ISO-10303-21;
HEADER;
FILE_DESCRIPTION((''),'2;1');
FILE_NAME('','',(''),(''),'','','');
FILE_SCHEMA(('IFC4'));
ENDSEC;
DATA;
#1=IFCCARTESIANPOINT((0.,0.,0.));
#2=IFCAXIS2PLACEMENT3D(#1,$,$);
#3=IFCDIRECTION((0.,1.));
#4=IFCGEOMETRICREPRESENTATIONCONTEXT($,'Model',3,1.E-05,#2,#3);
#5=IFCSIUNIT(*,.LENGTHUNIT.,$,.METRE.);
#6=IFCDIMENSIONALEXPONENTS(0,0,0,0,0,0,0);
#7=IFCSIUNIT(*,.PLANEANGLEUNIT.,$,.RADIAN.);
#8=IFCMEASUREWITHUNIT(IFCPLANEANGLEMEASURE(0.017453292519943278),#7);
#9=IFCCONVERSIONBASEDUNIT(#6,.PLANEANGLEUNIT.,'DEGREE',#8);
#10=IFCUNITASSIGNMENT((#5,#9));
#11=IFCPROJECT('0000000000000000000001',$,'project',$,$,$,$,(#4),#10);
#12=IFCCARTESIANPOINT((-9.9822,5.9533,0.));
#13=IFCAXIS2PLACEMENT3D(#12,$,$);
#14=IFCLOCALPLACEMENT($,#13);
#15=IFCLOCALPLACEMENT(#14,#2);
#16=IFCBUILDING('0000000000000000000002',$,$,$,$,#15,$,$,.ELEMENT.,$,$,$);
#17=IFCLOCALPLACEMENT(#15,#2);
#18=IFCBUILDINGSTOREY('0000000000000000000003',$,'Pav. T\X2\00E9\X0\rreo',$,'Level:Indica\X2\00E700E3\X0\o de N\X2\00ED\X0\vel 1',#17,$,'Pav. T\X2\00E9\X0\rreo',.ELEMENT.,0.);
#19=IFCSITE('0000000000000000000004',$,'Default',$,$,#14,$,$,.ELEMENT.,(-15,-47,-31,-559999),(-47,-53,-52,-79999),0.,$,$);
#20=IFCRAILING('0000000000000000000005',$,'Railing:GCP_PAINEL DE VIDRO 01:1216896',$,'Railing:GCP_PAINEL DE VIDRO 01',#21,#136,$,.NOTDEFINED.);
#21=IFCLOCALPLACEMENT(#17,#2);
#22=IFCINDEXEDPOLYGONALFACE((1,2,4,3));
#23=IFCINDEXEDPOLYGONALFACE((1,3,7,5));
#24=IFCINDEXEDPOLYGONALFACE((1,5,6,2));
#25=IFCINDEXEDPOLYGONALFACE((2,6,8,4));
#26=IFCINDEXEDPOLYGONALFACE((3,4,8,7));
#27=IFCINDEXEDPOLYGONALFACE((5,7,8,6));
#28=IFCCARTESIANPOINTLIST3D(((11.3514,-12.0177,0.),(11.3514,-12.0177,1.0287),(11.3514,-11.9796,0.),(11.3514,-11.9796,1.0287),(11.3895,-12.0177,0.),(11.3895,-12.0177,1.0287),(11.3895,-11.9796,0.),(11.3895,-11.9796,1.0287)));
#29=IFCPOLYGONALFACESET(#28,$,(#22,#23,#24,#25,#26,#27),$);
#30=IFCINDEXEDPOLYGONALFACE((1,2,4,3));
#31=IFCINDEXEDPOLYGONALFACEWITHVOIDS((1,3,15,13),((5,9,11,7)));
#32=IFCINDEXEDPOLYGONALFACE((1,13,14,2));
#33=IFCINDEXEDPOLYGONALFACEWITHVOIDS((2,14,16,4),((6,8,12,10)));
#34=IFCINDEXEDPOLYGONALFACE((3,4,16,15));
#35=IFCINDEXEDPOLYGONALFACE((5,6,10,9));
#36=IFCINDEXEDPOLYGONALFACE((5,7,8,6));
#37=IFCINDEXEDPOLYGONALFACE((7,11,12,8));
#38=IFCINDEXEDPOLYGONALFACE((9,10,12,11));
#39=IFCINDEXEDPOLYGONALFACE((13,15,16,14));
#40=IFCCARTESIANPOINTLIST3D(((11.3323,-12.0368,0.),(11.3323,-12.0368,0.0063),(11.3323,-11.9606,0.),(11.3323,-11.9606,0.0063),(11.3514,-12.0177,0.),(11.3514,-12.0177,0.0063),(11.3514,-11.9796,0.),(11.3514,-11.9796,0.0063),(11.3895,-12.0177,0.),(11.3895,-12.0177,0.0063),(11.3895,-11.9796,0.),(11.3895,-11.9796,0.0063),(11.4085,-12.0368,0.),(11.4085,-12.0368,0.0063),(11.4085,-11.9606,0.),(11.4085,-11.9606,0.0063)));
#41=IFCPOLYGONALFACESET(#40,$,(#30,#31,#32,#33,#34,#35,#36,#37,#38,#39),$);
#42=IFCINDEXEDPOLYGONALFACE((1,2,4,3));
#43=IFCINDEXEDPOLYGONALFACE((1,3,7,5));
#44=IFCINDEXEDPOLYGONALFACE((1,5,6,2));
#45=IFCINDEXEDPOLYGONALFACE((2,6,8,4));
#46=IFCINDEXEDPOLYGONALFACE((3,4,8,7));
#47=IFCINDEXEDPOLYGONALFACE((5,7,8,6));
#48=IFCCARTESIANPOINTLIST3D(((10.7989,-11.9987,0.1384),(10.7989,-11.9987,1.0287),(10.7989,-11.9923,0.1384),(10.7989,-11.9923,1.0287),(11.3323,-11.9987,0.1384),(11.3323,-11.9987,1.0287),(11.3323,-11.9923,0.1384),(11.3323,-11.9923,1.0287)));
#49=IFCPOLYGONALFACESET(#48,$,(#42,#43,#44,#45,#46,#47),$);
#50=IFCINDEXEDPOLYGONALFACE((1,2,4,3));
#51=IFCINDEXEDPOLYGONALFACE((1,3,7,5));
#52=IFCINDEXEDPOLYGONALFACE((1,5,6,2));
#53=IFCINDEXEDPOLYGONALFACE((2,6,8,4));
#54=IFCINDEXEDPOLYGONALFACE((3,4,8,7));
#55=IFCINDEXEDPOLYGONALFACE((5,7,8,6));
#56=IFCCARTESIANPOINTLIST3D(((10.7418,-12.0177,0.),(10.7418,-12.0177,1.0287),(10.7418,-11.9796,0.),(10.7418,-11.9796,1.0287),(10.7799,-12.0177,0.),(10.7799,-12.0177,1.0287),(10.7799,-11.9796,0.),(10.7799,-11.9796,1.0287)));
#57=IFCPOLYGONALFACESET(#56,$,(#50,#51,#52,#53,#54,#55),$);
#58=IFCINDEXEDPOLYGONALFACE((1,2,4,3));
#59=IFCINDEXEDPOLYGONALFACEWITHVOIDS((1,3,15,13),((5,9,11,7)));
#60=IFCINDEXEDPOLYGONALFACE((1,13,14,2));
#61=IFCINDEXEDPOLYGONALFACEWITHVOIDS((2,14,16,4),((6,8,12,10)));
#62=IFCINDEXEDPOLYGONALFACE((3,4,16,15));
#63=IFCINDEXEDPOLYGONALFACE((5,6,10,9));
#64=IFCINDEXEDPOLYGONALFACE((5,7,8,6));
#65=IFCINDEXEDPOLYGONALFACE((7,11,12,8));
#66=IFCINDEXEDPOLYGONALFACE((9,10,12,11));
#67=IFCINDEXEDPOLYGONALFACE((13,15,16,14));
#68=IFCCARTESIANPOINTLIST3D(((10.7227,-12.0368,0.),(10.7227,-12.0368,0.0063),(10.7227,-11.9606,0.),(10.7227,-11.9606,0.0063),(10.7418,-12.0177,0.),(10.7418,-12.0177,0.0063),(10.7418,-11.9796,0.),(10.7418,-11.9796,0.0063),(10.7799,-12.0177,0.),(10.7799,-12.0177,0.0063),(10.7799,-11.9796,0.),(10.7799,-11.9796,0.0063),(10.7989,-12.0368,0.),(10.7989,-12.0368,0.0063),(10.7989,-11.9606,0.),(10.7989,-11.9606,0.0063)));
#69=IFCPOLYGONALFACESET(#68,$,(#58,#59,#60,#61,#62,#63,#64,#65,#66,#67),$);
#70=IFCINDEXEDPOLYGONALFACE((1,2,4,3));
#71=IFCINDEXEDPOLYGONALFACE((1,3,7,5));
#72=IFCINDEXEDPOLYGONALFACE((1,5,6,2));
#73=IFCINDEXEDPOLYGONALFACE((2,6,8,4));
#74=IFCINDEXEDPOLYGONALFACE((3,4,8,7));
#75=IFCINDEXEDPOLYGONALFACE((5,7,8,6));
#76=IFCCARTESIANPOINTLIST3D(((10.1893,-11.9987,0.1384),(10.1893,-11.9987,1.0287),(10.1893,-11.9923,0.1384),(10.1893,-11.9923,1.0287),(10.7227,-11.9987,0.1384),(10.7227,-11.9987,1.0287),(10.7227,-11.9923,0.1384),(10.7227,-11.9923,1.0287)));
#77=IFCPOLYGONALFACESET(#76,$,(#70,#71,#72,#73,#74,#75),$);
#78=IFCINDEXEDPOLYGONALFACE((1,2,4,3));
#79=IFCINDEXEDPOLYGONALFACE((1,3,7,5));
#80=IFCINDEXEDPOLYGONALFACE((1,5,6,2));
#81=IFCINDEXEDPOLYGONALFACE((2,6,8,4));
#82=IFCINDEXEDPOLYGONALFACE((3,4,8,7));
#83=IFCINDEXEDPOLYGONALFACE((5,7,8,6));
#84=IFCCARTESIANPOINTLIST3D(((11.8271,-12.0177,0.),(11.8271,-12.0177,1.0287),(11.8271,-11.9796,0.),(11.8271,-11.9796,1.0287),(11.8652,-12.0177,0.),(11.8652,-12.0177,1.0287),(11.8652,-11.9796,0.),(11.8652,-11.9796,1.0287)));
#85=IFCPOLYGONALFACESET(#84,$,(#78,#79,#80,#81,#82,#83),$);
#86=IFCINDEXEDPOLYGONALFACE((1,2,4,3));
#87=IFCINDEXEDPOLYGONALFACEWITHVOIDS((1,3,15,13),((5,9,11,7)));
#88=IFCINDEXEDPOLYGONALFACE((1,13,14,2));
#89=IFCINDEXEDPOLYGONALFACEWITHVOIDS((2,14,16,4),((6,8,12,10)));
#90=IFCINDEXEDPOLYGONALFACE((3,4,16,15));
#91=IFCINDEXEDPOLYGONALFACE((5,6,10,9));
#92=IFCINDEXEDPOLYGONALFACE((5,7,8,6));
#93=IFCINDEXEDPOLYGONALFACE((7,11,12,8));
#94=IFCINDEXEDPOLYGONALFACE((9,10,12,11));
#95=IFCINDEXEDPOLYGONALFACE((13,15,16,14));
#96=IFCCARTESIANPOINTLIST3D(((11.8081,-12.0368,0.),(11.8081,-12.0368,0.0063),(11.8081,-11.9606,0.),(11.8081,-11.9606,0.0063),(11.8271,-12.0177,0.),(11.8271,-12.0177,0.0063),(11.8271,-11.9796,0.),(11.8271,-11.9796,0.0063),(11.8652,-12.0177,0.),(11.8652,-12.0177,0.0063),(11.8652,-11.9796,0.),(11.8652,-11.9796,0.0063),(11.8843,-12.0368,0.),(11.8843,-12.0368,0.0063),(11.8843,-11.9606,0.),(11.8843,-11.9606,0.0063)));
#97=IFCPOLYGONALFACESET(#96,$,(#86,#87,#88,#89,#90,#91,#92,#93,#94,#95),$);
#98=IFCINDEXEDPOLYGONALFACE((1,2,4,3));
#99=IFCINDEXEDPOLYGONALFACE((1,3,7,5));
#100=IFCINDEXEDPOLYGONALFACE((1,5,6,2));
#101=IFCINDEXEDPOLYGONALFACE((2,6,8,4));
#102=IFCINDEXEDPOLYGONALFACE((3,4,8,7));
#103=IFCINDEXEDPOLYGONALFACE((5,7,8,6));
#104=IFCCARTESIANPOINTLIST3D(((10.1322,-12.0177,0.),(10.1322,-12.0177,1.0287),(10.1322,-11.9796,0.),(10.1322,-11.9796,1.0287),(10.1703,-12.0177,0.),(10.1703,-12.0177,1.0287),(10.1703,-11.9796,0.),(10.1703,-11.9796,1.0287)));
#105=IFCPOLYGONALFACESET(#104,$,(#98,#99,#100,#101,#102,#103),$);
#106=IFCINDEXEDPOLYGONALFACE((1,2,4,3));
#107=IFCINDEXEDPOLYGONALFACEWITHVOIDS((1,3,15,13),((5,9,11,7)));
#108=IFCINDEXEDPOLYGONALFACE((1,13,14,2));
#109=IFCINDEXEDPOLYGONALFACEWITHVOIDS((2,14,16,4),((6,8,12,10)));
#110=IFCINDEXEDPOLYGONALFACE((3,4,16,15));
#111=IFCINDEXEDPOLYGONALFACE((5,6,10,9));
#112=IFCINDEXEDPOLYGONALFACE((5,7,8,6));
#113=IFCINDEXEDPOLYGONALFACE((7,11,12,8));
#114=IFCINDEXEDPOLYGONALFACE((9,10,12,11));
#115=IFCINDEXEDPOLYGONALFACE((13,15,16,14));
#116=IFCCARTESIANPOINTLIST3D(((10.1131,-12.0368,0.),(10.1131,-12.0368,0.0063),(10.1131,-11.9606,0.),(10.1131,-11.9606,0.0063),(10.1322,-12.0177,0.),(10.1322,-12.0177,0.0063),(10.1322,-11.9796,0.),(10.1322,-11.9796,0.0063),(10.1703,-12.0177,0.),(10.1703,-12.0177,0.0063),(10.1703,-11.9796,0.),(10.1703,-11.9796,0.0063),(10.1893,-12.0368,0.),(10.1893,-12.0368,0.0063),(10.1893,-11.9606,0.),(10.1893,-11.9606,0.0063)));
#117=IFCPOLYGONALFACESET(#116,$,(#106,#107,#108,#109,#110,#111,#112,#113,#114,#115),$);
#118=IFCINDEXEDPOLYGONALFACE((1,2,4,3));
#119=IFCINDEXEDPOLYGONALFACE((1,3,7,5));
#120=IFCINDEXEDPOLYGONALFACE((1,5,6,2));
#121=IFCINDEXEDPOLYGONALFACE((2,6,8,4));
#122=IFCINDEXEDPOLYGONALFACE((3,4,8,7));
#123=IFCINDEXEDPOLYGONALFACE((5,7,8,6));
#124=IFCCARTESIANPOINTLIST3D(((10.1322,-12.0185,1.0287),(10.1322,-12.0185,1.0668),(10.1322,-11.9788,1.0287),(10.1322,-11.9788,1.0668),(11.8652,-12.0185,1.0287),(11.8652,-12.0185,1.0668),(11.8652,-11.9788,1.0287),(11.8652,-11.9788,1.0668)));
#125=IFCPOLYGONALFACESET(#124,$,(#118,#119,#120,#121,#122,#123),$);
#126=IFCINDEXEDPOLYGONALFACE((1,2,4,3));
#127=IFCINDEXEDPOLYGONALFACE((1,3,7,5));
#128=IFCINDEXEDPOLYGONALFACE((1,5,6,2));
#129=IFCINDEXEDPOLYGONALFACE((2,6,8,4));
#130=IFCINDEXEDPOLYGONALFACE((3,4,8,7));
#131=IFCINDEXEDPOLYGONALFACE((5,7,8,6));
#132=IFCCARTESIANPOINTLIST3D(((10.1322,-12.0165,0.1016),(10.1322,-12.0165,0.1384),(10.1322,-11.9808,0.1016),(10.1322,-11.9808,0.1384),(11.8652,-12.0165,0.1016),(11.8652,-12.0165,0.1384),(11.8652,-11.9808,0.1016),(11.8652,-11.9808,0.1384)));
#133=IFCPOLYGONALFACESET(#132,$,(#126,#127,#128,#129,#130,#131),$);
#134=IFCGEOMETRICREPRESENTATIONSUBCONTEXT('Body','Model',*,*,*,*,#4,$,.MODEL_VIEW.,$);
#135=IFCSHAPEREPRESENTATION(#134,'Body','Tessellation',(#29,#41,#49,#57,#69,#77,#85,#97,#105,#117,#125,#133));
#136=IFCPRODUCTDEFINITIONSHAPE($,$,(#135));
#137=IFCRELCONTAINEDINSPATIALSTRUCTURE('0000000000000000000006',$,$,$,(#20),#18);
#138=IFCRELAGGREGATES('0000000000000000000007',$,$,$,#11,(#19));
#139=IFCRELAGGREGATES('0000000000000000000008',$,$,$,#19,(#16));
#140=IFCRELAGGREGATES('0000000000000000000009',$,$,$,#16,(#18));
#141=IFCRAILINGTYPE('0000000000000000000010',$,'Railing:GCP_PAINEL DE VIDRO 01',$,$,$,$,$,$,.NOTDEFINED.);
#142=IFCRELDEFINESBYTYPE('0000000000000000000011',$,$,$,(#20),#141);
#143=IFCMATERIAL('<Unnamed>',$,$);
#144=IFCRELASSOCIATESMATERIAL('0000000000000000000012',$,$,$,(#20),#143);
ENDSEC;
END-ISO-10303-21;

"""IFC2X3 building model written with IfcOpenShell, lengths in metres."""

from ifc_helpers import new_model, entity, si_unit, converted_unit, direction, frame, frame_2d, origin, origin_2d_with_axis, place, context, subcontext, project, spatial, polyline, rectangle, outline, extrude, material, type_object, element, save


model = new_model("IFC2X3")

# Units and contexts
model_context = context("Model", 3, precision=1e-05, world=origin(), true_north=direction((0.0, 1.0)))
body_context = subcontext(model_context, "Body", "Model", "MODEL_VIEW")
ifc_project = project(units=[si_unit("LENGTHUNIT", "METRE"), converted_unit("PLANEANGLEUNIT", "DEGREE", entity("IfcPlaneAngleMeasure", 0.017453292519943278), si_unit("PLANEANGLEUNIT", "RADIAN"), dimensions=[0, 0, 0, 0, 0, 0, 0])], contexts=[model_context])

# Site, building, storey
site_placement = place(None, frame((-9.9822, 5.9533, 0.0)))
site = spatial("IfcSite", under=ifc_project, at=site_placement, Name="Default", CompositionType="ELEMENT", RefLatitude=(-15, -47, -31, -559999), RefLongitude=(-47, -53, -52, -79999), RefElevation=0.0)
building_placement = place(site_placement, origin())
building = spatial("IfcBuilding", under=site, at=building_placement, CompositionType="ELEMENT")
storey_placement = place(building_placement, origin())
storey = spatial("IfcBuildingStorey", under=building, at=storey_placement, Name="Pav. Térreo", ObjectType="Level:Indicação de Nível 1", LongName="Pav. Térreo", CompositionType="ELEMENT", Elevation=0.0)

# Shared definitions
ifc_material_1 = material(Name="<Unnamed>")

# Railing
railing_type = type_object("IfcRailingType", Name="Railing:GCP_PAINEL DE VIDRO 01", PredefinedType="NOTDEFINED")
railing_placement = place(storey_placement, origin())
element("IfcRailing", 1, at=railing_placement, inside=storey, type_object=railing_type, material=ifc_material_1, Name="Railing:GCP_PAINEL DE VIDRO 01:1216896", ObjectType="Railing:GCP_PAINEL DE VIDRO 01", PredefinedType="NOTDEFINED", context=body_context, shape_type="SweptSolid", body=[
    extrude(rectangle(XDim=0.0381, YDim=0.0381, at=origin_2d_with_axis()), frame((11.3704, -11.9987, 0.0), z_axis=(0.0, 0.0, 1.0), x_axis=(0.0, 1.0, 0.0)), (0.0, 0.0, 1.0), 1.0287),
    extrude(outline(polyline([(-0.0381, -0.0381), (0.0381, -0.0381), (0.0381, 0.0381), (-0.0381, 0.0381), (-0.0381, -0.0381)]), holes=[polyline([(-0.0191, -0.0191), (-0.0191, 0.0191), (0.0191, 0.0191), (0.0191, -0.0191), (-0.0191, -0.0191)])]), frame((11.3704, -11.9987, 0.0)), (0.0, 0.0, 1.0), 0.0063),
    extrude(rectangle(XDim=0.0064, YDim=0.5334, at=frame_2d((0.0, 0.0), x_axis=(1.0, 0.0))), frame((11.0656, -11.9955, 0.1384), z_axis=(0.0, 0.0, 1.0), x_axis=(0.0, -1.0, 0.0)), (0.0, 0.0, 1.0), 0.8903),
    extrude(rectangle(XDim=0.0381, YDim=0.0381, at=origin_2d_with_axis()), frame((10.7608, -11.9987, 0.0), z_axis=(0.0, 0.0, 1.0), x_axis=(0.0, 1.0, 0.0)), (0.0, 0.0, 1.0), 1.0287),
    extrude(outline(polyline([(-0.0381, -0.0381), (0.0381, -0.0381), (0.0381, 0.0381), (-0.0381, 0.0381), (-0.0381, -0.0381)]), holes=[polyline([(-0.0191, -0.0191), (-0.0191, 0.0191), (0.0191, 0.0191), (0.0191, -0.0191), (-0.0191, -0.0191)])]), frame((10.7608, -11.9987, 0.0)), (0.0, 0.0, 1.0), 0.0063),
    extrude(rectangle(XDim=0.0064, YDim=0.5334, at=frame_2d((0.0, 0.0), x_axis=(1.0, 0.0))), frame((10.456, -11.9955, 0.1384), z_axis=(0.0, 0.0, 1.0), x_axis=(0.0, -1.0, 0.0)), (0.0, 0.0, 1.0), 0.8903),
    extrude(rectangle(XDim=0.0381, YDim=0.0381, at=origin_2d_with_axis()), frame((11.8462, -11.9987, 0.0), z_axis=(0.0, 0.0, 1.0), x_axis=(0.0, 1.0, 0.0)), (0.0, 0.0, 1.0), 1.0287),
    extrude(outline(polyline([(-0.0381, -0.0381), (0.0381, -0.0381), (0.0381, 0.0381), (-0.0381, 0.0381), (-0.0381, -0.0381)]), holes=[polyline([(-0.0191, -0.0191), (-0.0191, 0.0191), (0.0191, 0.0191), (0.0191, -0.0191), (-0.0191, -0.0191)])]), frame((11.8462, -11.9987, 0.0)), (0.0, 0.0, 1.0), 0.0063),
    extrude(rectangle(XDim=0.0381, YDim=0.0381, at=origin_2d_with_axis()), frame((10.1512, -11.9987, 0.0), z_axis=(0.0, 0.0, 1.0), x_axis=(0.0, 1.0, 0.0)), (0.0, 0.0, 1.0), 1.0287),
    extrude(outline(polyline([(-0.0381, -0.0381), (0.0381, -0.0381), (0.0381, 0.0381), (-0.0381, 0.0381), (-0.0381, -0.0381)]), holes=[polyline([(-0.0191, -0.0191), (-0.0191, 0.0191), (0.0191, 0.0191), (0.0191, -0.0191), (-0.0191, -0.0191)])]), frame((10.1512, -11.9987, 0.0)), (0.0, 0.0, 1.0), 0.0063),
    extrude(rectangle(XDim=1.733, YDim=0.0397, at=origin_2d_with_axis()), frame((10.9987, -11.9987, 1.0287)), (0.0, 0.0, 1.0), 0.0381),
    extrude(rectangle(XDim=1.733, YDim=0.0357, at=frame_2d((0.0, 0.0), x_axis=(1.0, 0.0))), frame((10.9987, -11.9987, 0.1016)), (0.0, 0.0, 1.0), 0.0368),
])

save(model, "model.ifc")
